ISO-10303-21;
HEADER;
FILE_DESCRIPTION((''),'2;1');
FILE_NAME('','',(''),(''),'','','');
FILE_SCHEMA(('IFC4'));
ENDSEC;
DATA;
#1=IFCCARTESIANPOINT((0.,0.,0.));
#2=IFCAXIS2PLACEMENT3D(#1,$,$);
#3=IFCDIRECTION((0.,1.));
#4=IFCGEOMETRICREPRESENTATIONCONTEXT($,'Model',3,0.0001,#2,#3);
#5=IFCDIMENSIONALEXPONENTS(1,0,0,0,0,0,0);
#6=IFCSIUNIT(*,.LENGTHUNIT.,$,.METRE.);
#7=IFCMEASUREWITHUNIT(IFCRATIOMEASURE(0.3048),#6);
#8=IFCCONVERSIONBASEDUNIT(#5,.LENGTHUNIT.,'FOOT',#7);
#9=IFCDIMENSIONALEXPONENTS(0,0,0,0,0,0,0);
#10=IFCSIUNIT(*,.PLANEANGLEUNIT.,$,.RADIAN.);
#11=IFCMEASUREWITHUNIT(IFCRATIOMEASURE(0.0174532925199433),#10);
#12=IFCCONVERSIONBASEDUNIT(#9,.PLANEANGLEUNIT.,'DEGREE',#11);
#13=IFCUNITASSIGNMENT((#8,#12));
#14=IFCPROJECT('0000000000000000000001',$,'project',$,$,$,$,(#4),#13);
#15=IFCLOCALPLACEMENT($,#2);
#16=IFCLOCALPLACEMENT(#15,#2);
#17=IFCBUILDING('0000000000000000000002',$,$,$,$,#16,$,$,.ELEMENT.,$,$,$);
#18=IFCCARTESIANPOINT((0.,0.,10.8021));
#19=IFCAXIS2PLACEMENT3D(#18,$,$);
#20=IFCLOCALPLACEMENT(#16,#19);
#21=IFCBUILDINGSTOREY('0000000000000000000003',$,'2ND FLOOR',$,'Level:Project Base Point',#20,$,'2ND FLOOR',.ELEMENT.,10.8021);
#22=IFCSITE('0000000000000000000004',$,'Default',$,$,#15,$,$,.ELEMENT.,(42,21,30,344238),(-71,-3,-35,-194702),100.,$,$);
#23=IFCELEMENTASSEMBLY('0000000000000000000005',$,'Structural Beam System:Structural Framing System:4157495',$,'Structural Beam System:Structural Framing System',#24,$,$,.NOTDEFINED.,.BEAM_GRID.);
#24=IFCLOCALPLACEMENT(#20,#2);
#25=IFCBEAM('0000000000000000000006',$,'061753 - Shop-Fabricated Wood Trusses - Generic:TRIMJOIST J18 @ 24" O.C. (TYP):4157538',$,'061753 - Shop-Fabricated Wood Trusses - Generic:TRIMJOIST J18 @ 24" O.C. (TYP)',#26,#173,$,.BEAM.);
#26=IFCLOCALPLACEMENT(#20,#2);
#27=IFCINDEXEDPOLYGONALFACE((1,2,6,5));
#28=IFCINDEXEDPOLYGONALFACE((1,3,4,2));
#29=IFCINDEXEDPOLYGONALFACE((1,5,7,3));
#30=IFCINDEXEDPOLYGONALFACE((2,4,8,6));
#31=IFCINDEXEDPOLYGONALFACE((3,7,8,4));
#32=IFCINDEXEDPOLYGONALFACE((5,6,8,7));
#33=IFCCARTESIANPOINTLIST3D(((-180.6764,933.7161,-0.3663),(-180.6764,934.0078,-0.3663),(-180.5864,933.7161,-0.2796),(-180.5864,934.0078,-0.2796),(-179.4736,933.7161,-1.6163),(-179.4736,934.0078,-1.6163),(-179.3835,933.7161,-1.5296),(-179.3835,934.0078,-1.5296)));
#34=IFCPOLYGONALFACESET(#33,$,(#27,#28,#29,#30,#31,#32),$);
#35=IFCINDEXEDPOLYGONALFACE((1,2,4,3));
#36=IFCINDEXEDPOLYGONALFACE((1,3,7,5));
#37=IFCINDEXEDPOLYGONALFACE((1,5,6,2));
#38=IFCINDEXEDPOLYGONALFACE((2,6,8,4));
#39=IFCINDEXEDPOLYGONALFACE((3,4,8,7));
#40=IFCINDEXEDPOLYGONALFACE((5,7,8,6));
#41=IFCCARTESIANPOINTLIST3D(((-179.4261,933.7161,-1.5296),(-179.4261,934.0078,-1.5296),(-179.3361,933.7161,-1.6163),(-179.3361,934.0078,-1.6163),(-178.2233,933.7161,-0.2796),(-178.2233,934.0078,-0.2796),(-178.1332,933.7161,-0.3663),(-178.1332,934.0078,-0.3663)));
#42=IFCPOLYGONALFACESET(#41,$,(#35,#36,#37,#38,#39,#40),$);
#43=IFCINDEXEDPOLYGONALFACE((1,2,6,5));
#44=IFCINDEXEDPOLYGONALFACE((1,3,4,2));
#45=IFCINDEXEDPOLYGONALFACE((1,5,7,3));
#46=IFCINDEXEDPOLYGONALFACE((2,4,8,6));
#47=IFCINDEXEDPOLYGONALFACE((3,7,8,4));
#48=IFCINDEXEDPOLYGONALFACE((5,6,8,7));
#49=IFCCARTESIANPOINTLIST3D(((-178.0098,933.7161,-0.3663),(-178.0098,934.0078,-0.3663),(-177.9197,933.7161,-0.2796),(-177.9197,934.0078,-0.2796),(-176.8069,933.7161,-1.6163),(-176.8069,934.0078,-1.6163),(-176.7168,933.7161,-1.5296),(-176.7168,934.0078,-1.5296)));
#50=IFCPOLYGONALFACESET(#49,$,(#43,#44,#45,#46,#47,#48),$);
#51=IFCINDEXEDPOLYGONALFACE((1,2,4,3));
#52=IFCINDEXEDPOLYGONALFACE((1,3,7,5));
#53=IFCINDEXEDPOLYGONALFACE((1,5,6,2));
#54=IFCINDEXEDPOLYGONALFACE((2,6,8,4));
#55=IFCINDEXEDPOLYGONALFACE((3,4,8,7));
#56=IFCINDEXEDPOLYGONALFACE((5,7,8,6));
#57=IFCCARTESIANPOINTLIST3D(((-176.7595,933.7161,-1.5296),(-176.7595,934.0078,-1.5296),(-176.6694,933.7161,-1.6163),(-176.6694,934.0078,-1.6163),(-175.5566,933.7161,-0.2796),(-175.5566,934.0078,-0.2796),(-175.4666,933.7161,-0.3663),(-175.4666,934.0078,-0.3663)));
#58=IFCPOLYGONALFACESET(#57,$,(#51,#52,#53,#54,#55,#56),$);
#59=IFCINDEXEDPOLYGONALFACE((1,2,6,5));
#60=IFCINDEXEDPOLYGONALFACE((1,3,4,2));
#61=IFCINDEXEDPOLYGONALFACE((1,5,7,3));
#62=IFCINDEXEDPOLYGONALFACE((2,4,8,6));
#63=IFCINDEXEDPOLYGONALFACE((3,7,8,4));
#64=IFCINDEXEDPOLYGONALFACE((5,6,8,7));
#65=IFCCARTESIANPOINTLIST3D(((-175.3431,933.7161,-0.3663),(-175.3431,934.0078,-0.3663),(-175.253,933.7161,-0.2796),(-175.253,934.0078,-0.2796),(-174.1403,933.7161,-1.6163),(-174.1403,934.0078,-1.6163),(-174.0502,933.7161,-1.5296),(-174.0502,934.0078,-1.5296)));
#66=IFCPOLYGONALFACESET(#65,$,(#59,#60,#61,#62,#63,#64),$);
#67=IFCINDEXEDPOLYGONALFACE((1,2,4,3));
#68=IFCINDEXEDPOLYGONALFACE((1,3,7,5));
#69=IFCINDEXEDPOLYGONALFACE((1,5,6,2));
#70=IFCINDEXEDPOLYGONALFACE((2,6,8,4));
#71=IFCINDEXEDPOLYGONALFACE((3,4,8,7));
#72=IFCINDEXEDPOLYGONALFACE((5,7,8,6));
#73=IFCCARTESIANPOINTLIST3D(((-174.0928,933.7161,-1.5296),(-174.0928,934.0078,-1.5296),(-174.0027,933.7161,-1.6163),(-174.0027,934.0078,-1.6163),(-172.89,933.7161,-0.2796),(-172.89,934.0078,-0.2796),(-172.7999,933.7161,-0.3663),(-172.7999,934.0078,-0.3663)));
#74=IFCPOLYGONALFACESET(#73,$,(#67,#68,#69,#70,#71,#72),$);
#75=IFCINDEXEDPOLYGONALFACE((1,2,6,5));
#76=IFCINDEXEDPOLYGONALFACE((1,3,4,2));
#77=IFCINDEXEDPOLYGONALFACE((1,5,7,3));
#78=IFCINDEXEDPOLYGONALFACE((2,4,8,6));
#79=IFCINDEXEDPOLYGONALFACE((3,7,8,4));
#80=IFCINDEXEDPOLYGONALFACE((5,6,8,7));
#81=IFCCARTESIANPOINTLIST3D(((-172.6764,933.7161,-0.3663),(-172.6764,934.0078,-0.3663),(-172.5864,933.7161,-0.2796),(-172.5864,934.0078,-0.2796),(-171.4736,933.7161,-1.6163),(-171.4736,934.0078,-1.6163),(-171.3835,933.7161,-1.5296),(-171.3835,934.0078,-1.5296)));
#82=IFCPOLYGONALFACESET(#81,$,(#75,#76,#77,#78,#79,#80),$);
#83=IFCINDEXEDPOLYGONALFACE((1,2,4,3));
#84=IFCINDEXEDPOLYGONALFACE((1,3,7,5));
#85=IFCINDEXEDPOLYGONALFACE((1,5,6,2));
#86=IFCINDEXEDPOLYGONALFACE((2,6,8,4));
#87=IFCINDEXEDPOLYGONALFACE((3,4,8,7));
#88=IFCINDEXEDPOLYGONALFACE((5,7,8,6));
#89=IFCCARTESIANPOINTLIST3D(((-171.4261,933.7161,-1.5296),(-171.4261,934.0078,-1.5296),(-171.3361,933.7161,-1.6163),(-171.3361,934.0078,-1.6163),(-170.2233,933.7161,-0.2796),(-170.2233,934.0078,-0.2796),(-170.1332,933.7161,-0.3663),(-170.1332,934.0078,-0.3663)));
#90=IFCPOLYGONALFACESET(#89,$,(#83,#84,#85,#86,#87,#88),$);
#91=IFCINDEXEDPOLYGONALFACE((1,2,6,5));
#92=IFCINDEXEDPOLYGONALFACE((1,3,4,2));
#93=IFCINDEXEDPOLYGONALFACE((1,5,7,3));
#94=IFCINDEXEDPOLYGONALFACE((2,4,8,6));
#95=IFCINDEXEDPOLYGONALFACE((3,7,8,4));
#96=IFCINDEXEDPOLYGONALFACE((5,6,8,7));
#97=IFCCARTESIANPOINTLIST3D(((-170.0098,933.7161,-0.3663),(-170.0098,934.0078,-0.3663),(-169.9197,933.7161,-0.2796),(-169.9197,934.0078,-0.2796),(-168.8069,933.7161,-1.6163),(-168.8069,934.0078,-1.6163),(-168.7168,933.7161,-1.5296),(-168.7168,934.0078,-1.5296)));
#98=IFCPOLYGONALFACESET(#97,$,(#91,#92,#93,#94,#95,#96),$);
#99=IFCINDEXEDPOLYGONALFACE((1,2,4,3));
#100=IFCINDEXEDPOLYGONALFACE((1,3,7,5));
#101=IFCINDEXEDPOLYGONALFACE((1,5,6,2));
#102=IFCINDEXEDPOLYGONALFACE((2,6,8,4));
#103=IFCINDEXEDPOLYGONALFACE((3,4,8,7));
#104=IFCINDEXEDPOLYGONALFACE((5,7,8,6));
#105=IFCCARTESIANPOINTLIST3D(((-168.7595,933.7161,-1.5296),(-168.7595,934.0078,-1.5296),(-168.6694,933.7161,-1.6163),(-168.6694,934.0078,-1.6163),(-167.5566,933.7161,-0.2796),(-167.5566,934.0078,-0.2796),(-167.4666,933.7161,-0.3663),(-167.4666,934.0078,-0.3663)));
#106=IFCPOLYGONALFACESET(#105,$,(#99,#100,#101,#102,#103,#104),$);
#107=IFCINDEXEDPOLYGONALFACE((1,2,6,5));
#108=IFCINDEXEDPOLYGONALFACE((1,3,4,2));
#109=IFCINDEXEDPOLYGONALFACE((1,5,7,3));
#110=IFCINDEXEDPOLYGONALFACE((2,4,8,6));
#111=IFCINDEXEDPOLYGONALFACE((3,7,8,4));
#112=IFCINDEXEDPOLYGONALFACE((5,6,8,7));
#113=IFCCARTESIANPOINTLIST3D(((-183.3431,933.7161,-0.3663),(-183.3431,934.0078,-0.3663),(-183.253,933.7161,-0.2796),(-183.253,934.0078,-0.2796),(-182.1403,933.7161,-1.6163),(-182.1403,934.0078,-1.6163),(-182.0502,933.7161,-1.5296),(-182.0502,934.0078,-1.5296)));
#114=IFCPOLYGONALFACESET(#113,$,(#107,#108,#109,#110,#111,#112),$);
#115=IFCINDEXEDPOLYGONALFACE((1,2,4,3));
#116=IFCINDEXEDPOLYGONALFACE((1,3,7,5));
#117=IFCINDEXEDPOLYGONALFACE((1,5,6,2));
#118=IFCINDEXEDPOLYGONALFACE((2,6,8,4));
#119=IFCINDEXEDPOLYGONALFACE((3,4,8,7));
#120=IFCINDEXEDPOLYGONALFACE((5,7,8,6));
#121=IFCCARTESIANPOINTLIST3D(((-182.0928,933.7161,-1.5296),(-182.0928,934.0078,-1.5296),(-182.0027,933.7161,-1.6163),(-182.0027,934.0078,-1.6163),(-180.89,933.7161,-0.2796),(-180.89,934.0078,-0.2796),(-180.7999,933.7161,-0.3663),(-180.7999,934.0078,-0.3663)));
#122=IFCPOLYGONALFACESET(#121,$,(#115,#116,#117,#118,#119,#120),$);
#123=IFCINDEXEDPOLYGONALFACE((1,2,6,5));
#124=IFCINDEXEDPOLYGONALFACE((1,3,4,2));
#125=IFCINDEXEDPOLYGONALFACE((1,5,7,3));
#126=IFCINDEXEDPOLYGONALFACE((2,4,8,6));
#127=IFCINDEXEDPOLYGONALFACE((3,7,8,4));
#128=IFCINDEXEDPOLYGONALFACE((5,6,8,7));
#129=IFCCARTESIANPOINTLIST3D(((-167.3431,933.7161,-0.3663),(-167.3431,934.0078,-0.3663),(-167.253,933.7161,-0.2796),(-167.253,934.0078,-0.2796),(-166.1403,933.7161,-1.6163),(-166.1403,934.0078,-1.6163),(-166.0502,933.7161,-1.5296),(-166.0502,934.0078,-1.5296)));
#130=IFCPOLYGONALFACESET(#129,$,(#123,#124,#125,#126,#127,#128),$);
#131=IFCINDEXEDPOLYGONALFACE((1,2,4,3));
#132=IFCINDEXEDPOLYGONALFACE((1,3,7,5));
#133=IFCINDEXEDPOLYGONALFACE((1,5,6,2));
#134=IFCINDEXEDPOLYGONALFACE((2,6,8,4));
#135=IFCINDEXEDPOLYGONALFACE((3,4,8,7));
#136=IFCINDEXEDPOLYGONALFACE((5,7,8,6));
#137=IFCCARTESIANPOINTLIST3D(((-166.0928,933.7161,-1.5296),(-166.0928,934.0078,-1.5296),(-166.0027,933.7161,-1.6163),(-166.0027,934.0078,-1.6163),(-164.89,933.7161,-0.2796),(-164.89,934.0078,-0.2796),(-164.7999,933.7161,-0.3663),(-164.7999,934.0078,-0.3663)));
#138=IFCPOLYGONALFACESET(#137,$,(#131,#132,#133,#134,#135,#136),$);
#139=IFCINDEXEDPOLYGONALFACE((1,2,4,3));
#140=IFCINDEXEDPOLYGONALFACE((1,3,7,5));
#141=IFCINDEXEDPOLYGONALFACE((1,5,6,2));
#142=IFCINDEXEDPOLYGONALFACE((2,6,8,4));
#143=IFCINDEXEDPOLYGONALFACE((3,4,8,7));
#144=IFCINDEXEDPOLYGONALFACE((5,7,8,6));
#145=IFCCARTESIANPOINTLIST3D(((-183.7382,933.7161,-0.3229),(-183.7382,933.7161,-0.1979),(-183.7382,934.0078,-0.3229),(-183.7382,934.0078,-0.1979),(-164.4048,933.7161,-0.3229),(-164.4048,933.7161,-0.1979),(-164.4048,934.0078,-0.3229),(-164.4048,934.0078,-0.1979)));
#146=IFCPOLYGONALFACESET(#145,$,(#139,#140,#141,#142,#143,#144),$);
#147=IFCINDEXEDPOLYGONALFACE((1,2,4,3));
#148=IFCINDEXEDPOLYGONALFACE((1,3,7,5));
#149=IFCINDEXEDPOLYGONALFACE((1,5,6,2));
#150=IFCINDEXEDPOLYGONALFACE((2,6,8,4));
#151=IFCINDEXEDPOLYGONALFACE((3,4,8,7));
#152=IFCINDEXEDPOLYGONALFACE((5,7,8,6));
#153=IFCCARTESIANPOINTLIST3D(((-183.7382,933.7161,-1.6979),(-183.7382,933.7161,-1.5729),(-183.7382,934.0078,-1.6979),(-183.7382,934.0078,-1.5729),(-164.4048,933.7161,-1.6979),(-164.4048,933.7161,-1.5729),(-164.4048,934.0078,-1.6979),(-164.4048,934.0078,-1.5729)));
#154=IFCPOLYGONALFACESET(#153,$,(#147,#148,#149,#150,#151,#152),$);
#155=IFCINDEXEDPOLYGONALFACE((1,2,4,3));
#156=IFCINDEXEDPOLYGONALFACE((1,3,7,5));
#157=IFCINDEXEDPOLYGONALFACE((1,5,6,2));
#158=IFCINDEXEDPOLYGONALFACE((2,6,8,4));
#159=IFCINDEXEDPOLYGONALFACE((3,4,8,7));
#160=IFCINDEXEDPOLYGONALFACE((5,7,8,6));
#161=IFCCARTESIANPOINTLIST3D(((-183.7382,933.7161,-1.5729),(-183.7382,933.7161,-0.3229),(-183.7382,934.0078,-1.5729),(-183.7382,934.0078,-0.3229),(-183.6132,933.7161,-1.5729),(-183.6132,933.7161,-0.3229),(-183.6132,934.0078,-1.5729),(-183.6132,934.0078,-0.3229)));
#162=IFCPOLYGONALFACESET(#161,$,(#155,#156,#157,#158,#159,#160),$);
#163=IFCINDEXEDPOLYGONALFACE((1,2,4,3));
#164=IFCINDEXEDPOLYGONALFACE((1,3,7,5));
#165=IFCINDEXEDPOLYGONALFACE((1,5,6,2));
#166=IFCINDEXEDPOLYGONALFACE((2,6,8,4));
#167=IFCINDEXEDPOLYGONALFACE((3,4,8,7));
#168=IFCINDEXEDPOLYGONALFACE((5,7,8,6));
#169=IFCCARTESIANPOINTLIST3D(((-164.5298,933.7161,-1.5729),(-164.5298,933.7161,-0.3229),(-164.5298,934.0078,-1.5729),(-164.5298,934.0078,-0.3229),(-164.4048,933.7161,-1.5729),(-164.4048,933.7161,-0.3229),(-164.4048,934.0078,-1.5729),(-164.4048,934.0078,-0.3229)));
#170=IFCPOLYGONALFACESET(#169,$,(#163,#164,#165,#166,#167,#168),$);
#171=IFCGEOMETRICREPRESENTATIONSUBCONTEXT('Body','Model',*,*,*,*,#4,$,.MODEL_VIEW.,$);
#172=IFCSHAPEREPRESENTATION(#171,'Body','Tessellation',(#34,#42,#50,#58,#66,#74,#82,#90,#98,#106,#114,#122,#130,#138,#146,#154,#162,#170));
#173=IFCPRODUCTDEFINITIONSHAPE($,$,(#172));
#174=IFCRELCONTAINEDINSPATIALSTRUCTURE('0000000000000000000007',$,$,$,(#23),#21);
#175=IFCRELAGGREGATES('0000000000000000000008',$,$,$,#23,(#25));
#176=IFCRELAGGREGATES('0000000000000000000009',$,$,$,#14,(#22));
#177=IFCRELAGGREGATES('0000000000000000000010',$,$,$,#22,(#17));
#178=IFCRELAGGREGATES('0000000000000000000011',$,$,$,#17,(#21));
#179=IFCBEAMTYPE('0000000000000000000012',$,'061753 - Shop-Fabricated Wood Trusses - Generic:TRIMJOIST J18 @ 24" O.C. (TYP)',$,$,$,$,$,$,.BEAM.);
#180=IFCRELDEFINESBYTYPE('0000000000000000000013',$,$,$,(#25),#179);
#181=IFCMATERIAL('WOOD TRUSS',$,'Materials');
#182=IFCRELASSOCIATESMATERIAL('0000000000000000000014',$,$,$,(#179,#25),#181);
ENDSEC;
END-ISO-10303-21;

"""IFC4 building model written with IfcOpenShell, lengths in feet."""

from ifc_helpers import new_model, entity, si_unit, converted_unit, direction, frame, frame_2d, origin, origin_2d_with_axis, place, context, subcontext, project, spatial, rectangle, extrude, source, transform, mapped, material, material_profile, profile_set, profile_usage, type_object, type_shapes, element, aggregate, save


model = new_model("IFC4")

# Units and contexts
model_context = context("Model", 3, precision=0.0001, world=origin(), true_north=direction((0.0, 1.0)))
body_context = subcontext(model_context, "Body", "Model", "MODEL_VIEW")
ifc_project = project(units=[converted_unit("LENGTHUNIT", "FOOT", entity("IfcRatioMeasure", 0.3048), si_unit("LENGTHUNIT", "METRE"), dimensions=[1, 0, 0, 0, 0, 0, 0]), converted_unit("PLANEANGLEUNIT", "DEGREE", entity("IfcRatioMeasure", 0.0174532925199433), si_unit("PLANEANGLEUNIT", "RADIAN"), dimensions=[0, 0, 0, 0, 0, 0, 0])], contexts=[model_context])

# Site, building, storey
site_placement = place(None, origin())
site = spatial("IfcSite", under=ifc_project, at=site_placement, Name="Default", CompositionType="ELEMENT", RefLatitude=(42, 21, 30, 344238), RefLongitude=(-71, -3, -35, -194702), RefElevation=100.0)
building_placement = place(site_placement, origin())
building = spatial("IfcBuilding", under=site, at=building_placement, CompositionType="ELEMENT")
storey_placement = place(building_placement, frame((0.0, 0.0, 10.8021)))
storey = spatial("IfcBuildingStorey", under=building, at=storey_placement, Name="2ND FLOOR", ObjectType="Level:Project Base Point", LongName="2ND FLOOR", CompositionType="ELEMENT", Elevation=10.8021)

# Element assembly, beam
ifc_material_1 = material(Name="WOOD TRUSS", Category="Materials")
ifc_material_profile_1 = material_profile(ifc_material_1, rectangle(XDim=1.7347, YDim=0.125, at=frame_2d((0.0, 0.0), x_axis=(1.0, 0.0))), Name="TRIMJOIST J18 @ 24\" O.C. (TYP)")
ifc_material_profile_2 = material_profile(ifc_material_1, rectangle(XDim=1.7347, YDim=0.125, at=frame_2d((0.0, 0.0), x_axis=(1.0, 0.0))), Name="TRIMJOIST J18 @ 24\" O.C. (TYP)")
ifc_material_profile_3 = material_profile(ifc_material_1, rectangle(XDim=1.7347, YDim=0.125, at=frame_2d((0.0, 0.0), x_axis=(1.0, 0.0))), Name="TRIMJOIST J18 @ 24\" O.C. (TYP)")
ifc_material_profile_4 = material_profile(ifc_material_1, rectangle(XDim=1.7347, YDim=0.125, at=frame_2d((0.0, 0.0), x_axis=(1.0, 0.0))), Name="TRIMJOIST J18 @ 24\" O.C. (TYP)")
ifc_material_profile_5 = material_profile(ifc_material_1, rectangle(XDim=1.7347, YDim=0.125, at=frame_2d((0.0, 0.0), x_axis=(1.0, 0.0))), Name="TRIMJOIST J18 @ 24\" O.C. (TYP)")
ifc_material_profile_6 = material_profile(ifc_material_1, rectangle(XDim=1.7347, YDim=0.125, at=frame_2d((0.0, 0.0), x_axis=(1.0, 0.0))), Name="TRIMJOIST J18 @ 24\" O.C. (TYP)")
ifc_material_profile_7 = material_profile(ifc_material_1, rectangle(XDim=1.7347, YDim=0.125, at=frame_2d((0.0, 0.0), x_axis=(1.0, 0.0))), Name="TRIMJOIST J18 @ 24\" O.C. (TYP)")
ifc_material_profile_8 = material_profile(ifc_material_1, rectangle(XDim=1.7347, YDim=0.125, at=frame_2d((0.0, 0.0), x_axis=(1.0, 0.0))), Name="TRIMJOIST J18 @ 24\" O.C. (TYP)")
ifc_material_profile_9 = material_profile(ifc_material_1, rectangle(XDim=1.7347, YDim=0.125, at=frame_2d((0.0, 0.0), x_axis=(1.0, 0.0))), Name="TRIMJOIST J18 @ 24\" O.C. (TYP)")
ifc_material_profile_10 = material_profile(ifc_material_1, rectangle(XDim=1.7347, YDim=0.125, at=origin_2d_with_axis()), Name="TRIMJOIST J18 @ 24\" O.C. (TYP)")
ifc_material_profile_11 = material_profile(ifc_material_1, rectangle(XDim=0.125, YDim=0.2917, at=origin_2d_with_axis()), Name="TRIMJOIST J18 @ 24\" O.C. (TYP)")
ifc_material_profile_12 = material_profile(ifc_material_1, rectangle(XDim=0.125, YDim=0.2917, at=origin_2d_with_axis()), Name="TRIMJOIST J18 @ 24\" O.C. (TYP)")
ifc_material_profile_13 = material_profile(ifc_material_1, rectangle(XDim=1.25, YDim=0.2917, at=origin_2d_with_axis()), Name="TRIMJOIST J18 @ 24\" O.C. (TYP)")
ifc_material_profile_14 = material_profile(ifc_material_1, rectangle(XDim=1.25, YDim=0.2917, at=origin_2d_with_axis()), Name="TRIMJOIST J18 @ 24\" O.C. (TYP)")
ifc_profile_set_1 = profile_set([ifc_material_profile_1, ifc_material_profile_2, ifc_material_profile_3, ifc_material_profile_4, ifc_material_profile_5, ifc_material_profile_6, ifc_material_profile_7, ifc_material_profile_8, ifc_material_profile_9, ifc_material_profile_10, ifc_material_profile_11, ifc_material_profile_12, ifc_material_profile_13, ifc_material_profile_14], Name="TRIMJOIST J18 @ 24\" O.C. (TYP)")
assembly_1_placement = place(storey_placement, origin())
assembly_1 = element("IfcElementAssembly", 1, at=assembly_1_placement, inside=storey, Name="Structural Beam System:Structural Framing System:4157495", ObjectType="Structural Beam System:Structural Framing System", AssemblyPlace="NOTDEFINED", PredefinedType="BEAM_GRID")
beam_type_1 = type_object("IfcBeamType", Name="061753 - Shop-Fabricated Wood Trusses - Generic:TRIMJOIST J18 @ 24\" O.C. (TYP)", PredefinedType="BEAM", material=ifc_profile_set_1)
shared_shape_1 = source(origin(), body_context, "Body", "SweptSolid", [
    extrude(rectangle(XDim=1.7347, YDim=0.125, at=frame_2d((0.0, 0.0), x_axis=(1.0, 0.0))), frame((5.9585, -0.1458, 0.0), z_axis=(0.0, 1.0, 0.0), x_axis=(0.693383, 0.0, 0.720569)), (0.0, 0.0, 1.0), 0.2917),
    extrude(rectangle(XDim=1.7347, YDim=0.125, at=origin_2d_with_axis()), frame((4.7082, -0.1458, 0.0), z_axis=(0.0, 1.0, 0.0), x_axis=(0.693383, 0.0, -0.720569)), (0.0, 0.0, 1.0), 0.2917),
    extrude(rectangle(XDim=1.7347, YDim=0.125, at=frame_2d((0.0, 0.0), x_axis=(1.0, 0.0))), frame((3.2918, -0.1458, 0.0), z_axis=(0.0, 1.0, 0.0), x_axis=(0.693383, 0.0, 0.720569)), (0.0, 0.0, 1.0), 0.2917),
    extrude(rectangle(XDim=1.7347, YDim=0.125, at=frame_2d((0.0, 0.0), x_axis=(1.0, 0.0))), frame((2.0415, -0.1458, 0.0), z_axis=(0.0, 1.0, 0.0), x_axis=(0.693383, 0.0, -0.720569)), (0.0, 0.0, 1.0), 0.2917),
    extrude(rectangle(XDim=1.7347, YDim=0.125, at=frame_2d((0.0, 0.0), x_axis=(1.0, 0.0))), frame((0.6251, -0.1458, 0.0), z_axis=(0.0, 1.0, 0.0), x_axis=(0.693383, 0.0, 0.720569)), (0.0, 0.0, 1.0), 0.2917),
    extrude(rectangle(XDim=1.7347, YDim=0.125, at=frame_2d((0.0, 0.0), x_axis=(1.0, 0.0))), frame((-0.6251, -0.1458, 0.0), z_axis=(0.0, 1.0, 0.0), x_axis=(0.693383, 0.0, -0.720569)), (0.0, 0.0, 1.0), 0.2917),
    extrude(rectangle(XDim=1.7347, YDim=0.125, at=frame_2d((0.0, 0.0), x_axis=(1.0, 0.0))), frame((-2.0415, -0.1458, 0.0), z_axis=(0.0, 1.0, 0.0), x_axis=(0.693383, 0.0, 0.720569)), (0.0, 0.0, 1.0), 0.2917),
    extrude(rectangle(XDim=1.7347, YDim=0.125, at=origin_2d_with_axis()), frame((-3.2918, -0.1458, 0.0), z_axis=(0.0, 1.0, 0.0), x_axis=(0.693383, 0.0, -0.720569)), (0.0, 0.0, 1.0), 0.2917),
    extrude(rectangle(XDim=1.7347, YDim=0.125, at=frame_2d((0.0, 0.0), x_axis=(1.0, 0.0))), frame((-4.7082, -0.1458, 0.0), z_axis=(0.0, 1.0, 0.0), x_axis=(0.693383, 0.0, 0.720569)), (0.0, 0.0, 1.0), 0.2917),
    extrude(rectangle(XDim=1.7347, YDim=0.125, at=frame_2d((0.0, 0.0), x_axis=(1.0, 0.0))), frame((-5.9585, -0.1458, 0.0), z_axis=(0.0, 1.0, 0.0), x_axis=(0.693383, 0.0, -0.720569)), (0.0, 0.0, 1.0), 0.2917),
    extrude(rectangle(XDim=1.7347, YDim=0.125, at=frame_2d((0.0, 0.0), x_axis=(1.0, 0.0))), frame((8.6251, -0.1458, 0.0), z_axis=(0.0, 1.0, 0.0), x_axis=(0.693383, 0.0, 0.720569)), (0.0, 0.0, 1.0), 0.2917),
    extrude(rectangle(XDim=1.7347, YDim=0.125, at=origin_2d_with_axis()), frame((7.3749, -0.1458, 0.0), z_axis=(0.0, 1.0, 0.0), x_axis=(0.693383, 0.0, -0.720569)), (0.0, 0.0, 1.0), 0.2917),
    extrude(rectangle(XDim=1.7347, YDim=0.125, at=frame_2d((0.0, 0.0), x_axis=(1.0, 0.0))), frame((-7.3749, -0.1458, 0.0), z_axis=(0.0, 1.0, 0.0), x_axis=(0.693383, 0.0, 0.720569)), (0.0, 0.0, 1.0), 0.2917),
    extrude(rectangle(XDim=1.7347, YDim=0.125, at=origin_2d_with_axis()), frame((-8.6251, -0.1458, 0.0), z_axis=(0.0, 1.0, 0.0), x_axis=(0.693383, 0.0, -0.720569)), (0.0, 0.0, 1.0), 0.2917),
    extrude(rectangle(XDim=0.125, YDim=0.2917, at=origin_2d_with_axis()), frame((-9.6667, 0.0, 0.6875), z_axis=(1.0, 0.0, 0.0), x_axis=(0.0, 0.0, -1.0)), (0.0, 0.0, 1.0), 19.3333),
    extrude(rectangle(XDim=0.125, YDim=0.2917, at=origin_2d_with_axis()), frame((-9.6667, 0.0, -0.6875), z_axis=(1.0, 0.0, 0.0), x_axis=(0.0, 0.0, -1.0)), (0.0, 0.0, 1.0), 19.3333),
    extrude(rectangle(XDim=1.25, YDim=0.2917, at=origin_2d_with_axis()), frame((9.5417, 0.0, 0.0), z_axis=(1.0, 0.0, 0.0), x_axis=(0.0, 0.0, -1.0)), (0.0, 0.0, 1.0), 0.125),
    extrude(rectangle(XDim=1.25, YDim=0.2917, at=origin_2d_with_axis()), frame((-9.6667, 0.0, 0.0), z_axis=(1.0, 0.0, 0.0), x_axis=(0.0, 0.0, -1.0)), (0.0, 0.0, 1.0), 0.125),
])
type_shapes(beam_type_1, [shared_shape_1])
ifc_profile_usage_1 = profile_usage(ifc_profile_set_1, cardinal=8)
beam_1_placement = place(assembly_1_placement, frame((-174.0715, 933.8619, -0.9479), z_axis=(0.0, 0.0, 1.0), x_axis=(-1.0, 0.0, 0.0)))
beam_1 = element("IfcBeam", 2, at=beam_1_placement, type_object=beam_type_1, material=ifc_profile_usage_1, Name="061753 - Shop-Fabricated Wood Trusses - Generic:TRIMJOIST J18 @ 24\" O.C. (TYP):4157538", ObjectType="061753 - Shop-Fabricated Wood Trusses - Generic:TRIMJOIST J18 @ 24\" O.C. (TYP)", PredefinedType="BEAM", context=body_context, shape_type="MappedRepresentation", body=[
    mapped(shared_shape_1, transform((0.0, 0.0, 0.0), scale=1.0)),
])
aggregate(assembly_1, [beam_1])

save(model, "model.ifc")
